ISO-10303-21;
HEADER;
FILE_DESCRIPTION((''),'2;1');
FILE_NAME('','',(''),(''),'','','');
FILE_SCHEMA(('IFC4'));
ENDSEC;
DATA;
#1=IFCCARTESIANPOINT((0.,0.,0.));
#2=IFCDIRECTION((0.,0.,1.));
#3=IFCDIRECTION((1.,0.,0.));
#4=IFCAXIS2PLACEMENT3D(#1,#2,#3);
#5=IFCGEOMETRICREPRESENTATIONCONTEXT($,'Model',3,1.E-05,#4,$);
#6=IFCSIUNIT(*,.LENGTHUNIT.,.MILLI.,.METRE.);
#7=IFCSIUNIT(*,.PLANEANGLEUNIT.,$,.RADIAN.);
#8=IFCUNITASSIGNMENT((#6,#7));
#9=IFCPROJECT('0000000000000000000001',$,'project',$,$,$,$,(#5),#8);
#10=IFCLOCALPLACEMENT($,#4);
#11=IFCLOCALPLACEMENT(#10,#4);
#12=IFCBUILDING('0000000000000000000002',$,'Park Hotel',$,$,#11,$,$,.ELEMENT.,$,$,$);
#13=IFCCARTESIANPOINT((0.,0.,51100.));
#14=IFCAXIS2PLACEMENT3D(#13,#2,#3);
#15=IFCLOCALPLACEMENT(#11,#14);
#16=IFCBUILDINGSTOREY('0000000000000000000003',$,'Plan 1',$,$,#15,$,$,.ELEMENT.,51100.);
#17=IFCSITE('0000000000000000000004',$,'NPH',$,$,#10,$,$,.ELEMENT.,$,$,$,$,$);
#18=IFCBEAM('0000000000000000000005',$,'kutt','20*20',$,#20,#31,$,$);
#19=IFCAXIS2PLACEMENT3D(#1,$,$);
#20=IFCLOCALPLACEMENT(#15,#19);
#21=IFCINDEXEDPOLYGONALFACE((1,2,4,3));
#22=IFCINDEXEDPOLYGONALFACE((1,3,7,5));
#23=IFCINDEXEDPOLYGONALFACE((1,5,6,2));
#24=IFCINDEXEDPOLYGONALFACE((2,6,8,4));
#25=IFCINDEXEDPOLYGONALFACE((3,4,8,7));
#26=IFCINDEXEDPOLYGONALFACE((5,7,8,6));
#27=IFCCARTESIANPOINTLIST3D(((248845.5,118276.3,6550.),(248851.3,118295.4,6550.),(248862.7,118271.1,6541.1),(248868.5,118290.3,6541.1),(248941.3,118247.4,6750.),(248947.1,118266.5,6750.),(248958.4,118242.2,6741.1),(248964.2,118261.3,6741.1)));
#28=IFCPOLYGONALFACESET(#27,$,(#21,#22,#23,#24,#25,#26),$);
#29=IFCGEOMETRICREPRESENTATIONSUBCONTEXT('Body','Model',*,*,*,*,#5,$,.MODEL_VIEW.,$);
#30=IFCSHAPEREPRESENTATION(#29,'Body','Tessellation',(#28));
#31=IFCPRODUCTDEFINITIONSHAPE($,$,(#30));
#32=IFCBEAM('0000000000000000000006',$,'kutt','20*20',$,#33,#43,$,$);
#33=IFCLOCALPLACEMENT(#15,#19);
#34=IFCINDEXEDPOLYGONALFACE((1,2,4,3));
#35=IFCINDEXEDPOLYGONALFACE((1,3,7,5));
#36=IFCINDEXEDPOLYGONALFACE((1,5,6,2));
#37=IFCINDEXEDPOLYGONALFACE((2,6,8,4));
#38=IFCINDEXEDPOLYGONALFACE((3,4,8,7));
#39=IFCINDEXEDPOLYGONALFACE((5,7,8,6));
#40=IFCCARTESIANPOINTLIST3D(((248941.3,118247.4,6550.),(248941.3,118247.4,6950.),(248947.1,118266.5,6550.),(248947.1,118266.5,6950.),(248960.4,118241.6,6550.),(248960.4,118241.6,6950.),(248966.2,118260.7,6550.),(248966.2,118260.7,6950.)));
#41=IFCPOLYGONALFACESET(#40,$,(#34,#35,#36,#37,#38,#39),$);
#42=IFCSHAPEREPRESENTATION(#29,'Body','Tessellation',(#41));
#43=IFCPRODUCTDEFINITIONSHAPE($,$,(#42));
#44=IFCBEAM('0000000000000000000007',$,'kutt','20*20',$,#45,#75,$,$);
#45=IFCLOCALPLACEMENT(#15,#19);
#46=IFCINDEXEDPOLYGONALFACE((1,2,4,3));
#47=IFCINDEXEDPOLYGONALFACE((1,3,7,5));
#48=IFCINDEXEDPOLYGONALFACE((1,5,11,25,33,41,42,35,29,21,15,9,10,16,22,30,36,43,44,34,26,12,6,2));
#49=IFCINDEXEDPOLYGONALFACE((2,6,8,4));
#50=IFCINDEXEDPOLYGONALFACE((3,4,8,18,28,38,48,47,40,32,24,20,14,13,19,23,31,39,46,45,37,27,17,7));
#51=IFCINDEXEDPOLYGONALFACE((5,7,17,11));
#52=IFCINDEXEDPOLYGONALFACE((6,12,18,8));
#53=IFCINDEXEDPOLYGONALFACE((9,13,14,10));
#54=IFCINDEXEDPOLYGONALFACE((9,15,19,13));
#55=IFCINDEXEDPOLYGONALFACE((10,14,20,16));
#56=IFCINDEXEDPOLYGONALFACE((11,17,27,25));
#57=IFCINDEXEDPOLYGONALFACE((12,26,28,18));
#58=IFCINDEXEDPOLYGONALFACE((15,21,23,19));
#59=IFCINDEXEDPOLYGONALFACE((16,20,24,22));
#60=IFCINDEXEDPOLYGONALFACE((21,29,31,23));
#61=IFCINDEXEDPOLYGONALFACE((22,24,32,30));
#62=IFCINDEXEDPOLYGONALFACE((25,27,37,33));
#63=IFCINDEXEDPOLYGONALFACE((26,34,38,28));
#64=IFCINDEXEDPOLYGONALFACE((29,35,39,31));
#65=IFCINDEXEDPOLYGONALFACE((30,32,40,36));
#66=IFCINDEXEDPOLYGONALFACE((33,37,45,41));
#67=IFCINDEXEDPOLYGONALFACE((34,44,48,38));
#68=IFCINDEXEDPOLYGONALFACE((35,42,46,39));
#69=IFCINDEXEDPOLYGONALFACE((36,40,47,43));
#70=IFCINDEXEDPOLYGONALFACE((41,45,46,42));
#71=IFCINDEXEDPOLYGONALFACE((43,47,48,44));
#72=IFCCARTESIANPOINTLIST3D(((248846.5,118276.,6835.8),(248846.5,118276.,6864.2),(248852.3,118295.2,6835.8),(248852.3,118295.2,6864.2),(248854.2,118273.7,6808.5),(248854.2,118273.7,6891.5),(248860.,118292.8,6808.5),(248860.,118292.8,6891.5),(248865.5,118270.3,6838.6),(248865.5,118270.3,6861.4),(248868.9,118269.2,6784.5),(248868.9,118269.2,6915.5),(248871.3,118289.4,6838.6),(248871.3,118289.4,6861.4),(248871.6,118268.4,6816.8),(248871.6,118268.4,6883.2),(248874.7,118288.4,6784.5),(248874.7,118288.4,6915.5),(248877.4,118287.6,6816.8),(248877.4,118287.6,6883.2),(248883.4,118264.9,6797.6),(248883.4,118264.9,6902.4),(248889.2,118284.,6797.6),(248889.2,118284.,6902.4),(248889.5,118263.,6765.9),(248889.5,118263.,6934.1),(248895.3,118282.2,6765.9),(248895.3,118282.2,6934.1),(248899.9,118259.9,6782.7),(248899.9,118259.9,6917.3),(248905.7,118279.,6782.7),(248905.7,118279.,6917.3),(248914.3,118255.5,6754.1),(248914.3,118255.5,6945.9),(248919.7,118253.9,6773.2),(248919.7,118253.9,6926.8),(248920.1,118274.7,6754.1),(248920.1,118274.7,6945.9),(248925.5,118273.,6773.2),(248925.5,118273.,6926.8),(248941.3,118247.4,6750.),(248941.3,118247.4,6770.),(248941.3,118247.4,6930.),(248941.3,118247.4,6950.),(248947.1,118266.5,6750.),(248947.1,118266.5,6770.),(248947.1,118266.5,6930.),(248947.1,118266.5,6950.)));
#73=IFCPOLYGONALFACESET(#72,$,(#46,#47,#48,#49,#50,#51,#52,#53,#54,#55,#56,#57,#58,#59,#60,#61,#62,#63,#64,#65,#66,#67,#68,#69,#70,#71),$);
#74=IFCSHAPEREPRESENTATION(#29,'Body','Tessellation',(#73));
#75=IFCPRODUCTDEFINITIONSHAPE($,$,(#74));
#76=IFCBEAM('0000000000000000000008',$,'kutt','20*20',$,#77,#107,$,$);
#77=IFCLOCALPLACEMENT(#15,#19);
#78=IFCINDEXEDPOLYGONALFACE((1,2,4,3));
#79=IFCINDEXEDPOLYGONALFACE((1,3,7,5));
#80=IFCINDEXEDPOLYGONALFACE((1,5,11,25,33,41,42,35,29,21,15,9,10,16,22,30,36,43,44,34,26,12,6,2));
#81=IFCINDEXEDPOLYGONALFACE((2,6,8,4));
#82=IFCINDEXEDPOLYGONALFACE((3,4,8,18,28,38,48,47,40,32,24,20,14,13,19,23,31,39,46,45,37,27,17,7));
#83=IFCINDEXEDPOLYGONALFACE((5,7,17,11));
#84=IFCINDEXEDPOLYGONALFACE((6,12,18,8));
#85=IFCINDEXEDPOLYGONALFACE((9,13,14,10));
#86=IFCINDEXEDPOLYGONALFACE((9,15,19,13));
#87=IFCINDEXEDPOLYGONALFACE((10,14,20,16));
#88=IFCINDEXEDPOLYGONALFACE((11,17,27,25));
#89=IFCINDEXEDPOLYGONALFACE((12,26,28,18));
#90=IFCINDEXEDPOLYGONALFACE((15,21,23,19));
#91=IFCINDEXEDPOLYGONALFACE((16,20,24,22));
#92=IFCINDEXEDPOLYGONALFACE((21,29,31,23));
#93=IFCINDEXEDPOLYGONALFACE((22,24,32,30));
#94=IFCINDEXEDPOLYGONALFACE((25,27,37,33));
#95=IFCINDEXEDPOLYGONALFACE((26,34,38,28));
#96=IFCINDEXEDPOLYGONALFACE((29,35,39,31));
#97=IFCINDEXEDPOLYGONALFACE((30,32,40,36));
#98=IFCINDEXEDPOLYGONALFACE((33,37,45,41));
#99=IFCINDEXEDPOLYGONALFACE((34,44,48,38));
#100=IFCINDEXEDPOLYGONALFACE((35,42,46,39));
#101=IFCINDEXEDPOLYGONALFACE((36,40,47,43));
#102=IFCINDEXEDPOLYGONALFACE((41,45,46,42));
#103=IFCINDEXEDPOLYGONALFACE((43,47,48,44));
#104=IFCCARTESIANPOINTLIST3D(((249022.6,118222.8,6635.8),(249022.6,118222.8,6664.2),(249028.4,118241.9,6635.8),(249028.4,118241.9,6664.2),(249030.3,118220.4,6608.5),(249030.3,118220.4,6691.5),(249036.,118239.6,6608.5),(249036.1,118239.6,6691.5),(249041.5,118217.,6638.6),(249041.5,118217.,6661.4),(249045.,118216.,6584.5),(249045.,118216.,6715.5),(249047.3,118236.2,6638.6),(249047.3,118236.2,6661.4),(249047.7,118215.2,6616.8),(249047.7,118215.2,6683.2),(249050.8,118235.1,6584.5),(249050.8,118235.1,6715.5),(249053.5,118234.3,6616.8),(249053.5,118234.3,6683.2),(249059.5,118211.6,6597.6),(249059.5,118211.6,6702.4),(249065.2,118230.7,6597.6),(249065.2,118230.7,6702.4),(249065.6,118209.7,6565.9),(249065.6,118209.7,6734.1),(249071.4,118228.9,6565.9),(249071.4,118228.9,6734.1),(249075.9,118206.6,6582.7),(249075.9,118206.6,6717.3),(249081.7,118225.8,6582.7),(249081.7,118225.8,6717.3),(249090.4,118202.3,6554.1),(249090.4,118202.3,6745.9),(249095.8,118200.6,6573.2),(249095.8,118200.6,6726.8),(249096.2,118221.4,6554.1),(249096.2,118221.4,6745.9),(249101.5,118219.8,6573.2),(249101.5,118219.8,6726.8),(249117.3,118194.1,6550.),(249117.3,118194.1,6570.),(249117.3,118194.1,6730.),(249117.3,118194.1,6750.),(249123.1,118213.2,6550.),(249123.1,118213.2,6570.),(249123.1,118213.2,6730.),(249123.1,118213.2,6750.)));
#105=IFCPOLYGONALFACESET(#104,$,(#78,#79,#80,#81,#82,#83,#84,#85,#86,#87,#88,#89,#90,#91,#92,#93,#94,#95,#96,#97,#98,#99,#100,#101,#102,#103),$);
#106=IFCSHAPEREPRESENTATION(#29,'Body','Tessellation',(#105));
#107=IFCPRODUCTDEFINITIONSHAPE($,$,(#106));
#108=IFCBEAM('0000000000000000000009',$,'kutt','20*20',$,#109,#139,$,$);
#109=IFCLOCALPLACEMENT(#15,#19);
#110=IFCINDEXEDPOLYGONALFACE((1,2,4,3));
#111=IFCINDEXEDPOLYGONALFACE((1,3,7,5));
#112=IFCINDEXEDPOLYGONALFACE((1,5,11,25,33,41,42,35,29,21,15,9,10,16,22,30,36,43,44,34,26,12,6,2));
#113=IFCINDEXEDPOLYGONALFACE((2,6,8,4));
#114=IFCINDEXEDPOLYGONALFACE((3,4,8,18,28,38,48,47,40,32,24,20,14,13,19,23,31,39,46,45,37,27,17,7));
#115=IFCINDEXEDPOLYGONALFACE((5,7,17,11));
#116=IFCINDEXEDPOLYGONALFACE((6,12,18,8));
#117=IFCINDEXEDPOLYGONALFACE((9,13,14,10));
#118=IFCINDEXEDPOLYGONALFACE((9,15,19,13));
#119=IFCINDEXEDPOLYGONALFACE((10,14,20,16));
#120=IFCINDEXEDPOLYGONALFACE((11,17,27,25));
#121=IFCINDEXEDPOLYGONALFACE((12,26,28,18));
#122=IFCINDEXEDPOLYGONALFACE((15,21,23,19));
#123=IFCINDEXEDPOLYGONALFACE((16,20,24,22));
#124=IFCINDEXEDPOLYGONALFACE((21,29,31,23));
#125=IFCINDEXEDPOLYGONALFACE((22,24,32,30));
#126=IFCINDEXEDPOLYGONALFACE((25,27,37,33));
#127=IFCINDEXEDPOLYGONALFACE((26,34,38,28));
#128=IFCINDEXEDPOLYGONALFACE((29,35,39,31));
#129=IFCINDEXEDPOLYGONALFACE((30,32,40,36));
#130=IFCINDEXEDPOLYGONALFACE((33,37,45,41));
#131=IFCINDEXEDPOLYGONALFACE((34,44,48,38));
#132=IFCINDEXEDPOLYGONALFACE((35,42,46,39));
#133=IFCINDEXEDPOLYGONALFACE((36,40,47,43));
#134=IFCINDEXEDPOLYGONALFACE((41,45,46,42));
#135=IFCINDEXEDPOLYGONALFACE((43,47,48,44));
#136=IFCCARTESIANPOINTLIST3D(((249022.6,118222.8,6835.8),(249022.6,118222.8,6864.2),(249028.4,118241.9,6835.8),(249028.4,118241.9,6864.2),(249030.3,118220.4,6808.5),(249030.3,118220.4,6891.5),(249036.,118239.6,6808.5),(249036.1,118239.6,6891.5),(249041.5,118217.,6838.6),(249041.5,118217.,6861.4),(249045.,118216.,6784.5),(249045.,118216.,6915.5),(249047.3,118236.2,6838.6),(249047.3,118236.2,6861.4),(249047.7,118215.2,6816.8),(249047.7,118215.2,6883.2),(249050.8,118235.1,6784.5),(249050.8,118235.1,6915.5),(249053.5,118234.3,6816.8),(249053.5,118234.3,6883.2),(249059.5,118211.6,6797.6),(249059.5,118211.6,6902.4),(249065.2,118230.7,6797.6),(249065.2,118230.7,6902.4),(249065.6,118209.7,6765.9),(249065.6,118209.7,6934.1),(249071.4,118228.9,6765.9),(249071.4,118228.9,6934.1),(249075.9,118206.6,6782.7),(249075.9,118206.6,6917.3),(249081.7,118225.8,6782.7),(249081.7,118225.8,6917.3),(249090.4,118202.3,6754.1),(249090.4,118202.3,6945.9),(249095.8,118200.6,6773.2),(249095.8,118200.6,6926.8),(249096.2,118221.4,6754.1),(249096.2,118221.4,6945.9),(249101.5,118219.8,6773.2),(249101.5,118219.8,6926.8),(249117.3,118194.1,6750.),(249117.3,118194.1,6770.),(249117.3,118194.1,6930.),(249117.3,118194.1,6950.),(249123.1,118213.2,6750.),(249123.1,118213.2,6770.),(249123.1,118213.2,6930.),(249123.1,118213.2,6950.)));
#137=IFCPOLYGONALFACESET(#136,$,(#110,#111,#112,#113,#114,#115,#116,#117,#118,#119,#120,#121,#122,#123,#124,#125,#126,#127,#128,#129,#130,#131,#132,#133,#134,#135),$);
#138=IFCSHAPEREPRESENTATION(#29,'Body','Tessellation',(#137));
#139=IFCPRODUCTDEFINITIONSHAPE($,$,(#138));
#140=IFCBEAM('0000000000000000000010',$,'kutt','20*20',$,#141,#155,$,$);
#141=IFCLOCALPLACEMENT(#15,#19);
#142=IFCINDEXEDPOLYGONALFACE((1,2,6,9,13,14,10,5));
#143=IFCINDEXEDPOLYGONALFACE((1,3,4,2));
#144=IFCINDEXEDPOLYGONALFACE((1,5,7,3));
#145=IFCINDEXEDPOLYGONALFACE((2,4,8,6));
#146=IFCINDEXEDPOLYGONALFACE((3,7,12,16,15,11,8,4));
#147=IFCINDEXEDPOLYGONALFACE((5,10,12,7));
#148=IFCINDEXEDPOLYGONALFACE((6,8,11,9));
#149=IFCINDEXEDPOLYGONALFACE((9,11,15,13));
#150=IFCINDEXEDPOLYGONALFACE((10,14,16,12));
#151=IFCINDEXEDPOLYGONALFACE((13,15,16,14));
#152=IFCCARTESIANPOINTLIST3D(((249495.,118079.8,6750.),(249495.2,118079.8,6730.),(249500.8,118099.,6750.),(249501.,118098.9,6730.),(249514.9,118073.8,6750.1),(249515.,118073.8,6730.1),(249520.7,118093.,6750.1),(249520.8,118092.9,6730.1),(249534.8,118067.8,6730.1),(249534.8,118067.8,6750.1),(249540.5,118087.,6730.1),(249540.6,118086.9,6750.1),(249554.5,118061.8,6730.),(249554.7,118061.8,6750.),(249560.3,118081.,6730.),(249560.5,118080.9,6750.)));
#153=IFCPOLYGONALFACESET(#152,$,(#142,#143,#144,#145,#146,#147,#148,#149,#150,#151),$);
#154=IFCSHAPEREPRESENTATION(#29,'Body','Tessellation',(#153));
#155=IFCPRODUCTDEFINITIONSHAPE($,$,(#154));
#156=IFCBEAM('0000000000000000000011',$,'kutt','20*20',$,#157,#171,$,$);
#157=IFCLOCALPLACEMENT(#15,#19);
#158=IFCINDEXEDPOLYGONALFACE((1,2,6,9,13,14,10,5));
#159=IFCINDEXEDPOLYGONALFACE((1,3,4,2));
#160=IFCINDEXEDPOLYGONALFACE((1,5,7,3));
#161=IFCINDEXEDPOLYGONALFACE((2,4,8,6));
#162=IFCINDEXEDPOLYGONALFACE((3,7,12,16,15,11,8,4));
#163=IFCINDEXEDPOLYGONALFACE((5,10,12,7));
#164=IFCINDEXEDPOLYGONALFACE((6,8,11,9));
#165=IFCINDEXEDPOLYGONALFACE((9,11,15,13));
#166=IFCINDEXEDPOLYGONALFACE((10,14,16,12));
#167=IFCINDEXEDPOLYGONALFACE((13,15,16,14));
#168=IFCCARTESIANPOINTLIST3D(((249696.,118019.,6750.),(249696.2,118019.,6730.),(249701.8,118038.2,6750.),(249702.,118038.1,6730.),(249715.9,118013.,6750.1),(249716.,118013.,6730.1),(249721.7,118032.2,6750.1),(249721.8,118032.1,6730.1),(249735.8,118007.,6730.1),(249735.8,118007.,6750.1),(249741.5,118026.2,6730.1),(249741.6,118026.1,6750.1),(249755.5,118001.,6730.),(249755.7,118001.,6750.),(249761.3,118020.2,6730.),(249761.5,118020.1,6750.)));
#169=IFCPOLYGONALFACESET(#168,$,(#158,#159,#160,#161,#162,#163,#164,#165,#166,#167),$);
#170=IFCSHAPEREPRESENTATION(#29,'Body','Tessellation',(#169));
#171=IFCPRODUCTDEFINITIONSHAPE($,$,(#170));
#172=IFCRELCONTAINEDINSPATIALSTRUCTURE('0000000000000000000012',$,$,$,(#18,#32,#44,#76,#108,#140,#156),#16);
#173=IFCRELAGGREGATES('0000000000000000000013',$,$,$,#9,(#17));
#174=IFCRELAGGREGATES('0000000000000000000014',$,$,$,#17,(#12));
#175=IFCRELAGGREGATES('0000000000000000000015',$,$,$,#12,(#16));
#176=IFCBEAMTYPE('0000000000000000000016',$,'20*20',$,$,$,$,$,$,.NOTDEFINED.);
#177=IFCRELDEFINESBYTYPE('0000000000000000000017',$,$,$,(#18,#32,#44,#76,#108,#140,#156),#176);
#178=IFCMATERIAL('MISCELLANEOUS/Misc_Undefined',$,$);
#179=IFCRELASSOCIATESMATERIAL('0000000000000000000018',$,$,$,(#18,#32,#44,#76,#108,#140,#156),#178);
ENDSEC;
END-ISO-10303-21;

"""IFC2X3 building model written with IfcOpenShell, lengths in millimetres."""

from ifc_helpers import new_model, entity, si_unit, frame, origin_with_axes, origin_2d_with_axis, place, context, subcontext, project, spatial, rectangle, extrude, material, type_object, element, save


model = new_model("IFC2X3")

# Units and contexts
model_context = context("Model", 3, precision=1e-05, world=origin_with_axes())
body_context = subcontext(model_context, "Body", "Model", "MODEL_VIEW")
ifc_project = project(units=[si_unit("LENGTHUNIT", "METRE", prefix="MILLI"), si_unit("PLANEANGLEUNIT", "RADIAN")], contexts=[model_context])

# Site, building, storey
site_placement = place(None, origin_with_axes())
site = spatial("IfcSite", under=ifc_project, at=site_placement, Name="NPH", CompositionType="ELEMENT")
building_placement = place(site_placement, origin_with_axes())
building = spatial("IfcBuilding", under=site, at=building_placement, Name="Park Hotel", CompositionType="ELEMENT")
storey_placement = place(building_placement, frame((0.0, 0.0, 51100.0), z_axis=(0.0, 0.0, 1.0), x_axis=(1.0, 0.0, 0.0)))
storey = spatial("IfcBuildingStorey", under=building, at=storey_placement, Name="Plan 1", CompositionType="ELEMENT", Elevation=51100.0)

# Beams
ifc_material_1 = material(Name="MISCELLANEOUS/Misc_Undefined")
beam_type_1 = type_object("IfcBeamType", Name="20*20", PredefinedType="NOTDEFINED")
beam_1_placement = place(storey_placement, frame((248952.7, 118254.3, 6745.5), z_axis=(-0.289533, -0.957168, 0.0), x_axis=(-0.428059, 0.129483, -0.894427)))
element("IfcBeam", 1, at=beam_1_placement, inside=storey, type_object=beam_type_1, material=ifc_material_1, Name="kutt", Description="20*20", context=body_context, shape_type="SweptSolid", body=[
    extrude(rectangle(XDim=20.0, YDim=20.0, at=origin_2d_with_axis()), frame((223.6, 0.0, 0.0), z_axis=(-1.0, 0.0, 0.0), x_axis=(0.0, -1.0, 0.0)), (0.0, 0.0, 1.0), 223.6),
])
beam_2_placement = place(storey_placement, frame((248953.7, 118254.0, 6950.0), z_axis=(0.289538, 0.957167, -0.000001), x_axis=(0.0, -0.000001, -1.0)))
element("IfcBeam", 2, at=beam_2_placement, inside=storey, type_object=beam_type_1, material=ifc_material_1, Name="kutt", Description="20*20", context=body_context, shape_type="SweptSolid", body=[
    extrude(rectangle(XDim=20.0, YDim=20.0, at=origin_2d_with_axis()), frame((400.0, 0.0, 0.0), z_axis=(-1.0, 0.0, 0.0), x_axis=(0.0, -1.0, 0.0)), (0.0, 0.0, 1.0), 400.0),
])
beam_3_placement = place(storey_placement, frame((248944.2, 118256.9, 6940.0), z_axis=(-0.289538, -0.957167, 0.000003), x_axis=(-0.000001, -0.000003, -1.0)))
ifc_direction_1 = entity("IfcDirection", [0.0, -1.0, 0.0])
element("IfcBeam", 3, at=beam_3_placement, inside=storey, type_object=beam_type_1, material=ifc_material_1, Name="kutt", Description="20*20", context=body_context, shape_type="SweptSolid", body=[
    entity("IfcRevolvedAreaSolid", entity("IfcRectangleProfileDef", "AREA", None, entity("IfcAxis2Placement2D", entity("IfcCartesianPoint", [0.0, 0.0]), entity("IfcDirection", [1.0, 0.0])), 20.0, 20.0), entity("IfcAxis2Placement3D", entity("IfcCartesianPoint", [180.0, 0.0, 0.0]), ifc_direction_1, entity("IfcDirection", [1.0, 0.0, 0.0])), entity("IfcAxis1Placement", entity("IfcCartesianPoint", [-90.0, 0.0, 0.0]), ifc_direction_1), 3.141593),
])
beam_4_placement = place(storey_placement, frame((249120.2, 118203.7, 6740.0), z_axis=(-0.289538, -0.957167, 0.000003), x_axis=(-0.000001, -0.000003, -1.0)))
ifc_direction_2 = entity("IfcDirection", [0.0, -1.0, 0.0])
element("IfcBeam", 4, at=beam_4_placement, inside=storey, type_object=beam_type_1, material=ifc_material_1, Name="kutt", Description="20*20", context=body_context, shape_type="SweptSolid", body=[
    entity("IfcRevolvedAreaSolid", entity("IfcRectangleProfileDef", "AREA", None, entity("IfcAxis2Placement2D", entity("IfcCartesianPoint", [0.0, 0.0]), entity("IfcDirection", [1.0, 0.0])), 20.0, 20.0), entity("IfcAxis2Placement3D", entity("IfcCartesianPoint", [180.0, 0.0, 0.0]), ifc_direction_2, entity("IfcDirection", [1.0, 0.0, 0.0])), entity("IfcAxis1Placement", entity("IfcCartesianPoint", [-90.0, 0.0, 0.0]), ifc_direction_2), 3.141593),
])
beam_5_placement = place(storey_placement, frame((249120.2, 118203.7, 6940.0), z_axis=(-0.289538, -0.957167, 0.000003), x_axis=(-0.000001, -0.000003, -1.0)))
ifc_direction_3 = entity("IfcDirection", [0.0, -1.0, 0.0])
element("IfcBeam", 5, at=beam_5_placement, inside=storey, type_object=beam_type_1, material=ifc_material_1, Name="kutt", Description="20*20", context=body_context, shape_type="SweptSolid", body=[
    entity("IfcRevolvedAreaSolid", entity("IfcRectangleProfileDef", "AREA", None, entity("IfcAxis2Placement2D", entity("IfcCartesianPoint", [0.0, 0.0]), entity("IfcDirection", [1.0, 0.0])), 20.0, 20.0), entity("IfcAxis2Placement3D", entity("IfcCartesianPoint", [180.0, 0.0, 0.0]), ifc_direction_3, entity("IfcDirection", [1.0, 0.0, 0.0])), entity("IfcAxis1Placement", entity("IfcCartesianPoint", [-90.0, 0.0, 0.0]), ifc_direction_3), 3.141593),
])
beam_6_placement = place(storey_placement, frame((249557.5, 118071.4, 6740.0), z_axis=(-0.289539, -0.957166, 0.0), x_axis=(-0.957166, 0.289539, 0.0)))
element("IfcBeam", 6, at=beam_6_placement, inside=storey, type_object=beam_type_1, material=ifc_material_1, Name="kutt", Description="20*20", context=body_context, shape_type="SweptSolid", body=[
    entity("IfcRevolvedAreaSolid", entity("IfcRectangleProfileDef", "AREA", None, entity("IfcAxis2Placement2D", entity("IfcCartesianPoint", [0.0, 0.0]), entity("IfcDirection", [1.0, 0.0])), 20.0, 20.0), entity("IfcAxis2Placement3D", entity("IfcCartesianPoint", [62.2, 0.0, 0.0]), entity("IfcDirection", [-0.999946, -0.010393, 0.0]), entity("IfcDirection", [0.010393, -0.999946, 0.0])), entity("IfcAxis1Placement", entity("IfcCartesianPoint", [-2990.0, 0.0, 0.0]), entity("IfcDirection", [0.0, -1.0, 0.0])), 0.020787),
])
beam_7_placement = place(storey_placement, frame((249758.5, 118010.6, 6740.0), z_axis=(-0.289539, -0.957166, 0.0), x_axis=(-0.957166, 0.289539, 0.0)))
element("IfcBeam", 7, at=beam_7_placement, inside=storey, type_object=beam_type_1, material=ifc_material_1, Name="kutt", Description="20*20", context=body_context, shape_type="SweptSolid", body=[
    entity("IfcRevolvedAreaSolid", entity("IfcRectangleProfileDef", "AREA", None, entity("IfcAxis2Placement2D", entity("IfcCartesianPoint", [0.0, 0.0]), entity("IfcDirection", [1.0, 0.0])), 20.0, 20.0), entity("IfcAxis2Placement3D", entity("IfcCartesianPoint", [62.2, 0.0, 0.0]), entity("IfcDirection", [-0.999946, -0.010393, 0.0]), entity("IfcDirection", [0.010393, -0.999946, 0.0])), entity("IfcAxis1Placement", entity("IfcCartesianPoint", [-2990.0, 0.0, 0.0]), entity("IfcDirection", [0.0, -1.0, 0.0])), 0.020787),
])

save(model, "model.ifc")
